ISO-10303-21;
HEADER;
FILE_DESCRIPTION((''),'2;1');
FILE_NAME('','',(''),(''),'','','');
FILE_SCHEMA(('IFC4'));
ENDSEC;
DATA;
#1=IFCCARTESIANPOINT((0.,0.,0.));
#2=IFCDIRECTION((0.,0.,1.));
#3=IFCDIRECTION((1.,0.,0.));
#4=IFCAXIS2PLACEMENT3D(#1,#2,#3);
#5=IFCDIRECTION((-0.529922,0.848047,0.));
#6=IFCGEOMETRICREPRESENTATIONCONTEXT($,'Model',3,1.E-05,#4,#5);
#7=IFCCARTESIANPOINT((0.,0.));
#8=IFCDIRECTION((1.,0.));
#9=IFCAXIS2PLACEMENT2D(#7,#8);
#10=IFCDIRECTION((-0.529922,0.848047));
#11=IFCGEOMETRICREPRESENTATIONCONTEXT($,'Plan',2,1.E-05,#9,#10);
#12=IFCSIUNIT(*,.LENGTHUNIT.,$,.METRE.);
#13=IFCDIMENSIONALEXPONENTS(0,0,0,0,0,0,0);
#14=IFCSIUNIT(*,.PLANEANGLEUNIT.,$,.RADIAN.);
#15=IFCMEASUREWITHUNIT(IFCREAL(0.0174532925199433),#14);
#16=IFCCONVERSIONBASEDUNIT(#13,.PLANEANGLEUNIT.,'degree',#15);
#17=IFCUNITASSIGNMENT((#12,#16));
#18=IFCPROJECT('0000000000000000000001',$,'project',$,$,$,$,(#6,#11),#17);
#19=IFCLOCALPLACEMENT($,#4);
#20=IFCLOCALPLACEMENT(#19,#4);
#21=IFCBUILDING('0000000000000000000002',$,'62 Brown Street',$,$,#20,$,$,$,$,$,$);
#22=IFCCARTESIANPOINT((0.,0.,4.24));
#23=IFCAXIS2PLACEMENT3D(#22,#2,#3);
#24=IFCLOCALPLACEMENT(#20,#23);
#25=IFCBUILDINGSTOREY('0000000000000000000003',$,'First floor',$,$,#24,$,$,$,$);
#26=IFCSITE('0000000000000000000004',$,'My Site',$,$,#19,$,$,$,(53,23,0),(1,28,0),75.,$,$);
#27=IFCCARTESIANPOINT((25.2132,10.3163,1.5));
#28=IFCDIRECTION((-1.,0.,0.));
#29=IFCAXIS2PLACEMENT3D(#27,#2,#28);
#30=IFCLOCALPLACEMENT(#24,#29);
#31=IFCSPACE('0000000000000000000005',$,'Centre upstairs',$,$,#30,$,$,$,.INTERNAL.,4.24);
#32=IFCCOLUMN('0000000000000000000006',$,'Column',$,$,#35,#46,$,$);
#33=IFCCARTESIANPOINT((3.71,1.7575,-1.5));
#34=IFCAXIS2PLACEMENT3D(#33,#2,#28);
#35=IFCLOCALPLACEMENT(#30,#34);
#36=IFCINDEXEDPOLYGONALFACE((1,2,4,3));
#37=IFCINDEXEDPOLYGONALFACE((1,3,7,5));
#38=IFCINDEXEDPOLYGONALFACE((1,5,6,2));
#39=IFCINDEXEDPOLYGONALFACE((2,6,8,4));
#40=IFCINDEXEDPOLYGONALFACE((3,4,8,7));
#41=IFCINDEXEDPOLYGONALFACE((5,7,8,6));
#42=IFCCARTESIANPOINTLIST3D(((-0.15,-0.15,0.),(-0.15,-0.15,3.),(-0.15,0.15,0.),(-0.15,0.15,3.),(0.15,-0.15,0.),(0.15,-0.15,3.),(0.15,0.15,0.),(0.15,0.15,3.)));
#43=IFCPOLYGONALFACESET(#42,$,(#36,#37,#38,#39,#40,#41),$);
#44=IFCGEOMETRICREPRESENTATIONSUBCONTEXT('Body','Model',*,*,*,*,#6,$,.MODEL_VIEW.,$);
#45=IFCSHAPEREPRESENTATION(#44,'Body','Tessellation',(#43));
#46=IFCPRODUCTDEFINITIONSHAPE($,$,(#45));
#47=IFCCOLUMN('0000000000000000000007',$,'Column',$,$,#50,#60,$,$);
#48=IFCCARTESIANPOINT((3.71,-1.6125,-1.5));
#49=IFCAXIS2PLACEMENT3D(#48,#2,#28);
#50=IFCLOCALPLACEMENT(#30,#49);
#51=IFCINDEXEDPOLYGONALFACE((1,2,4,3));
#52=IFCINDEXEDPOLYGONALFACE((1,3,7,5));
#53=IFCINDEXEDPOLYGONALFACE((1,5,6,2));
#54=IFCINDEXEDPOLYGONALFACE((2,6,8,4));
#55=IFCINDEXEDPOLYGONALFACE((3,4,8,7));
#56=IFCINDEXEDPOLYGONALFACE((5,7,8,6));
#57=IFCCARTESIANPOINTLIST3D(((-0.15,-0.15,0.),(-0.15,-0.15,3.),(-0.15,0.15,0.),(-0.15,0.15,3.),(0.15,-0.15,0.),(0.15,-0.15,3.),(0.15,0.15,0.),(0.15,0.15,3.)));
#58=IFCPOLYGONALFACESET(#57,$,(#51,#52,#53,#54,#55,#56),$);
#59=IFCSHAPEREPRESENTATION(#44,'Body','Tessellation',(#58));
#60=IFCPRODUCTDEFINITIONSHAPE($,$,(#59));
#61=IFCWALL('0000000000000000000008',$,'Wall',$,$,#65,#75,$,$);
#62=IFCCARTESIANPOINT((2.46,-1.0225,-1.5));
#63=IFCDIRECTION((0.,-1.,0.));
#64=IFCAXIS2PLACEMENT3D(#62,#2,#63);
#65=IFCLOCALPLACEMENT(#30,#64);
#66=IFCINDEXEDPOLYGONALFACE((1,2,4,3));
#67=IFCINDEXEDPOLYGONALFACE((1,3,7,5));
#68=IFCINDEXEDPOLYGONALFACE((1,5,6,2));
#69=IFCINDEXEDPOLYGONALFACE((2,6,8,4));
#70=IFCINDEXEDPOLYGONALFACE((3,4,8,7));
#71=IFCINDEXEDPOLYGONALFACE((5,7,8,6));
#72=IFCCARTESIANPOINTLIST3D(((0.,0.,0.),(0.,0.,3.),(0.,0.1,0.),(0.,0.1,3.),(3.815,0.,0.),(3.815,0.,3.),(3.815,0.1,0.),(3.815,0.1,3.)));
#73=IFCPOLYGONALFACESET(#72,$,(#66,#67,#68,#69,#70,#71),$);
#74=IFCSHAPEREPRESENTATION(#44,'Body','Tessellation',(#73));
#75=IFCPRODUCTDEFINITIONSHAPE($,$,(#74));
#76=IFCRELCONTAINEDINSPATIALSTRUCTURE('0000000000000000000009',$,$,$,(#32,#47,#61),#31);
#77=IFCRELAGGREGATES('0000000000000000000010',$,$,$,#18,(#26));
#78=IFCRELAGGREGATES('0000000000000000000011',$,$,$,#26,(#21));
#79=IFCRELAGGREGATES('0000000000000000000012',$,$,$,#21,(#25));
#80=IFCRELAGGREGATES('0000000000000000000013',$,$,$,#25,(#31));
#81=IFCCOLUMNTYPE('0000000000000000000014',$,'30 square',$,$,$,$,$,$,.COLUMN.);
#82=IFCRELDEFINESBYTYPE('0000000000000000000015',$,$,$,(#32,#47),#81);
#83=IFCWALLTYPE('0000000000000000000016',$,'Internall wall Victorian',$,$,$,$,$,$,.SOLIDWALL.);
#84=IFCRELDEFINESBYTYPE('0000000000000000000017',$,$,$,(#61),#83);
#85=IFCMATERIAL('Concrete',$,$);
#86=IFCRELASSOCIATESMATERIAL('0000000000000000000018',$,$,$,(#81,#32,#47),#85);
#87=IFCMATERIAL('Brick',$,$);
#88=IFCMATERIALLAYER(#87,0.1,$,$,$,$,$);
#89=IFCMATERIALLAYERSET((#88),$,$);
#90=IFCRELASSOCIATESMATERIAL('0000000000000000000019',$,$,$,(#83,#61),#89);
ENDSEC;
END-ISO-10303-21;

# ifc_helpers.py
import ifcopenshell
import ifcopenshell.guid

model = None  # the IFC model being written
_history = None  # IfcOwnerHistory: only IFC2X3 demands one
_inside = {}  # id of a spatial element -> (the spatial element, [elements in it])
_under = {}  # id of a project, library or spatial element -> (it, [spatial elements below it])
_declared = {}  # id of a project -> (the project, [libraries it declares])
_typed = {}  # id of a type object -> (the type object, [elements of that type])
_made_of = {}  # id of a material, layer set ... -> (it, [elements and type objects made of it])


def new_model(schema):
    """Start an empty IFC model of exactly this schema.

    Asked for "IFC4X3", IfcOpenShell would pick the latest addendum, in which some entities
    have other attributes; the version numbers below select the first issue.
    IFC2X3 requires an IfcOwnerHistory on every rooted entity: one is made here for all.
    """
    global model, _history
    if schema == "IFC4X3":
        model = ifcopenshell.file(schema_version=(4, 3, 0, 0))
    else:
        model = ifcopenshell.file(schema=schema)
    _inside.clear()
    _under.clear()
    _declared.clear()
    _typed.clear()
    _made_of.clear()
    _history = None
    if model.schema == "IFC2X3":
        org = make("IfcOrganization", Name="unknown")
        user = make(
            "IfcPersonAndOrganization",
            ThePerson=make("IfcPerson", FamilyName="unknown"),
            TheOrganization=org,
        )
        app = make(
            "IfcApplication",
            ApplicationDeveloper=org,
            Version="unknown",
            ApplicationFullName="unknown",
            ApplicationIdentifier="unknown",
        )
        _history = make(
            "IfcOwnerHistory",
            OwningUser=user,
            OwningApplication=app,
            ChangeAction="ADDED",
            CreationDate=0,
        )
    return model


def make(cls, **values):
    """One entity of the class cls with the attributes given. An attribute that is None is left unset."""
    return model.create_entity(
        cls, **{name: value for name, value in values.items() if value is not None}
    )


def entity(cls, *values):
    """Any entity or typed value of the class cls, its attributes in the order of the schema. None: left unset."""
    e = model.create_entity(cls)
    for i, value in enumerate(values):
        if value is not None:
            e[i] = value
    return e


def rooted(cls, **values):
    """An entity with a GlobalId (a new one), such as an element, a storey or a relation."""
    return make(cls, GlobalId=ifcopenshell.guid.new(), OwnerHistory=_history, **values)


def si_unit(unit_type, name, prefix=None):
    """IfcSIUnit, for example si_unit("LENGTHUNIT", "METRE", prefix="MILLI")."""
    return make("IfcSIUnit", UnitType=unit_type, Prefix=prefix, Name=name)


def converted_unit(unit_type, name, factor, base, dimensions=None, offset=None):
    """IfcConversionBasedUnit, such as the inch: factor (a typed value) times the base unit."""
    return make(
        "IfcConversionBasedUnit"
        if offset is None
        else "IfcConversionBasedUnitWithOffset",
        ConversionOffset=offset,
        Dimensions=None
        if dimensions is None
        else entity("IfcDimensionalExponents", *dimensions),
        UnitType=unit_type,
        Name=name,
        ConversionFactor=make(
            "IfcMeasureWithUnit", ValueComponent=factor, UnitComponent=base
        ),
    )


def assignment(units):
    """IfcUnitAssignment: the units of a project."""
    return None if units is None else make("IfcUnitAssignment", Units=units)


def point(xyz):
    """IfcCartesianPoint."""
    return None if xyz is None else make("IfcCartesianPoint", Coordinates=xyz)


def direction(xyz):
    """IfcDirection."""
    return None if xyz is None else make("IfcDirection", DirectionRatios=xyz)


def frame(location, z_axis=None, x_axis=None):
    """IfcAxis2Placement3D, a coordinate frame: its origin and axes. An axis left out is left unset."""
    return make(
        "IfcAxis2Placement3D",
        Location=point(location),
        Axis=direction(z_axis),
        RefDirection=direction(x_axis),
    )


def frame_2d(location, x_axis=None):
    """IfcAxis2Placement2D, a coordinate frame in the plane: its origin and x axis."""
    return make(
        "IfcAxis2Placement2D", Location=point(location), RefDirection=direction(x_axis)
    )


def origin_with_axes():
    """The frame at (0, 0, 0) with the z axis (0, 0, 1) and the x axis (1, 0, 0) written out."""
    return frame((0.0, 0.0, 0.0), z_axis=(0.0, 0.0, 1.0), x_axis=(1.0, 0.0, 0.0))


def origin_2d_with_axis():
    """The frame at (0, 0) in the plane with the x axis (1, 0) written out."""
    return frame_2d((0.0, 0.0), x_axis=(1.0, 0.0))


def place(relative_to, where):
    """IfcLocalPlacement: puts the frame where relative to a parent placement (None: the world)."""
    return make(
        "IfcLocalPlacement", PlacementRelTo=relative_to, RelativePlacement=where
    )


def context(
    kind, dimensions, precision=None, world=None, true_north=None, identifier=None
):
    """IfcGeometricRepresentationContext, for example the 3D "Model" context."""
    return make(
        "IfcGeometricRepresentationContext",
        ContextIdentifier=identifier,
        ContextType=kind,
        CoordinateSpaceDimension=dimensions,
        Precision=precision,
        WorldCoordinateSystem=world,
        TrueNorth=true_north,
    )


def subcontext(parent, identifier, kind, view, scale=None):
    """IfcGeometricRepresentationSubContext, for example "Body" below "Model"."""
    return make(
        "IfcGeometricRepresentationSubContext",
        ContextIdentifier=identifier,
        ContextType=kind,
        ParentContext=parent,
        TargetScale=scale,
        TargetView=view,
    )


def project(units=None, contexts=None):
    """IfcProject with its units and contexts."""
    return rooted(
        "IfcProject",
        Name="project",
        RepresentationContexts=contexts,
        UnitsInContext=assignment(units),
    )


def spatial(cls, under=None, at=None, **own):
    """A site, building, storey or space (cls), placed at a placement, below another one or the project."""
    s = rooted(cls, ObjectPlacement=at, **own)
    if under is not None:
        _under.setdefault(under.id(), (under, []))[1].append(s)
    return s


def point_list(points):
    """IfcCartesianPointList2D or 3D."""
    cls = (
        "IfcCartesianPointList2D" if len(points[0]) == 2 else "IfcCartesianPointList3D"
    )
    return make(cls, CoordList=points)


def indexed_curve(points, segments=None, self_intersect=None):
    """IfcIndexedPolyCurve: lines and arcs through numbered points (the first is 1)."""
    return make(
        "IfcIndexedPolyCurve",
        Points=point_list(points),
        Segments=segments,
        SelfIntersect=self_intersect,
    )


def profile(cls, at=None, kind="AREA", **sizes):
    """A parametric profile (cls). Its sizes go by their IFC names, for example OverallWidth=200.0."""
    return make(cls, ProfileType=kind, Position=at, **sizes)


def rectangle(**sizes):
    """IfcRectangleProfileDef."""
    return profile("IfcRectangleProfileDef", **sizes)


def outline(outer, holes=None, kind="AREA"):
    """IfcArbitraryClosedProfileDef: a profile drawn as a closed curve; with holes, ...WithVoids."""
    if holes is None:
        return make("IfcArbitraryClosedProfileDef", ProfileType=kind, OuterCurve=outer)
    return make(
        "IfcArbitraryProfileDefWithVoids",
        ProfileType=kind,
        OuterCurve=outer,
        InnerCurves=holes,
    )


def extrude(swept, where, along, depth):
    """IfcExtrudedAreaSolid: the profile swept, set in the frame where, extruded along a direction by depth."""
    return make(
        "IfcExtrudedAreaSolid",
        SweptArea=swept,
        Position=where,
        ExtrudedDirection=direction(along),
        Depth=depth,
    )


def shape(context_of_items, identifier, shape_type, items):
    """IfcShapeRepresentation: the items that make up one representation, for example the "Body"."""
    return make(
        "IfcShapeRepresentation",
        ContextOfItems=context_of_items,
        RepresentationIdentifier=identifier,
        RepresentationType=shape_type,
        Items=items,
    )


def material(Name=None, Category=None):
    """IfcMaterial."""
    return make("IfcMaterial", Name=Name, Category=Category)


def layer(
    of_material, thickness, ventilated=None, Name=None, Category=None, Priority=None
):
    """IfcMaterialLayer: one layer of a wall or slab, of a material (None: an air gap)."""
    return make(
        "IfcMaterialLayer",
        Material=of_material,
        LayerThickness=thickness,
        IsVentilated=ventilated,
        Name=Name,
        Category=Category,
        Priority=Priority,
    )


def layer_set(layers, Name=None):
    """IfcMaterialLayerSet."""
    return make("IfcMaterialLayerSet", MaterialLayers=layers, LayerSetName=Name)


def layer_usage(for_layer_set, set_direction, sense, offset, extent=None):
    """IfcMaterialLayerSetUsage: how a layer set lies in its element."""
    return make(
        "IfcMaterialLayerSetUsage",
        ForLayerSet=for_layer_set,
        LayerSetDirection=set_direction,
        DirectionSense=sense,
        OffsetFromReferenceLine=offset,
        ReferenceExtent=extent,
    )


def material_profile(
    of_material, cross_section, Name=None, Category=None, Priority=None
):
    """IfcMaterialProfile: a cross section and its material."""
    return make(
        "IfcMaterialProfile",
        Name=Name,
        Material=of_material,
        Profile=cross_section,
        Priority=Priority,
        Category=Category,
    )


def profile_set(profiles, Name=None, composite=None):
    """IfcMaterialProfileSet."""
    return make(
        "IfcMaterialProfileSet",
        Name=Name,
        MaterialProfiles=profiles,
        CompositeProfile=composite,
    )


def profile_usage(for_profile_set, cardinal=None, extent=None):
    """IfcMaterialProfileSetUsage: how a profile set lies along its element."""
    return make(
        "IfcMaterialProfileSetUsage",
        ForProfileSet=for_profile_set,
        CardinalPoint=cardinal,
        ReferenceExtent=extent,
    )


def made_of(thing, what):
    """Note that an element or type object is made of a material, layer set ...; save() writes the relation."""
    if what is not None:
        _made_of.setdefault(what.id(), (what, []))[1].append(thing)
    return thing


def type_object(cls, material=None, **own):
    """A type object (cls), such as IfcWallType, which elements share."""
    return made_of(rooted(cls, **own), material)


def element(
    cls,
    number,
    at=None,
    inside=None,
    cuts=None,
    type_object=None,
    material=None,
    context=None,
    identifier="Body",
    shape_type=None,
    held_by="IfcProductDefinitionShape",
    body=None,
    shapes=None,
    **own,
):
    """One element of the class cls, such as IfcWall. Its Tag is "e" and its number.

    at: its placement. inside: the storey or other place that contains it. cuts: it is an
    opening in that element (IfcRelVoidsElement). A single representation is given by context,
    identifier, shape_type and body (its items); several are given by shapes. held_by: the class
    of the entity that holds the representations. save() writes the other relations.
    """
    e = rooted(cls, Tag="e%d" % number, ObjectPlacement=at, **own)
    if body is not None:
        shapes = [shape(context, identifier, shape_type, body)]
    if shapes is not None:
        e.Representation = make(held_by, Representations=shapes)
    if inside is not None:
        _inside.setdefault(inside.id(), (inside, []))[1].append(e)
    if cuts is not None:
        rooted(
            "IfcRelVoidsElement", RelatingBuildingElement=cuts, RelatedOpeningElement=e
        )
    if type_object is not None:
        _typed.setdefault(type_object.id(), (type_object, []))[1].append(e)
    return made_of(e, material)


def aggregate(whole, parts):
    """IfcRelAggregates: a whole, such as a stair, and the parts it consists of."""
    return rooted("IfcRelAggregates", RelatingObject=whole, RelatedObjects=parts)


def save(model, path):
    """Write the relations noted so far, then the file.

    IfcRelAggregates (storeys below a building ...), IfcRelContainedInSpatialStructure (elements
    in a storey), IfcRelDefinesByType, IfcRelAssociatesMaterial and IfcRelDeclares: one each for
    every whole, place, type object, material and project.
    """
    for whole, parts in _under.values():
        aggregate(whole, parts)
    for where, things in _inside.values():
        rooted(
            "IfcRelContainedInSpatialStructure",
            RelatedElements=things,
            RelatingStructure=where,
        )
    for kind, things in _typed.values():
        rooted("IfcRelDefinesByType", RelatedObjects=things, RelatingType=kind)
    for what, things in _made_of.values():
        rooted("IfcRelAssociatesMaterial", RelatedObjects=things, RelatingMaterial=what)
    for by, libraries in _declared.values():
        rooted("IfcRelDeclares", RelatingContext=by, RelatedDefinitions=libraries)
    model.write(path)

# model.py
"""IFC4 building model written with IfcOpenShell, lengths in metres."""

from ifc_helpers import new_model, entity, si_unit, converted_unit, direction, frame, origin_with_axes, origin_2d_with_axis, place, context, subcontext, project, spatial, indexed_curve, rectangle, outline, extrude, material, layer, layer_set, layer_usage, material_profile, profile_set, profile_usage, type_object, element, save


model = new_model("IFC4")

# Units and contexts
model_context = context("Model", 3, precision=1e-05, world=origin_with_axes(), true_north=direction((-0.529922, 0.848047, 0.0)))
plan_context = context("Plan", 2, precision=1e-05, world=origin_2d_with_axis(), true_north=direction((-0.529922, 0.848047)))
body_context_1 = subcontext(model_context, "Body", "Model", "MODEL_VIEW")
ifc_project = project(units=[si_unit("LENGTHUNIT", "METRE"), converted_unit("PLANEANGLEUNIT", "degree", entity("IfcReal", 0.0174532925199433), si_unit("PLANEANGLEUNIT", "RADIAN"), dimensions=[0, 0, 0, 0, 0, 0, 0])], contexts=[model_context, plan_context])

# Site, building, storey, space
site_placement = place(None, origin_with_axes())
site = spatial("IfcSite", under=ifc_project, at=site_placement, Name="My Site", RefLatitude=(53, 23, 0), RefLongitude=(1, 28, 0), RefElevation=75.0)
building_placement = place(site_placement, origin_with_axes())
building = spatial("IfcBuilding", under=site, at=building_placement, Name="62 Brown Street")
storey_placement = place(building_placement, frame((0.0, 0.0, 4.24), z_axis=(0.0, 0.0, 1.0), x_axis=(1.0, 0.0, 0.0)))
storey = spatial("IfcBuildingStorey", under=building, at=storey_placement, Name="First floor")
space_placement = place(storey_placement, frame((25.2132, 10.3163, 1.5), z_axis=(0.0, 0.0, 1.0), x_axis=(-1.0, 0.0, 0.0)))
space = spatial("IfcSpace", under=storey, at=space_placement, Name="Centre upstairs", PredefinedType="INTERNAL", ElevationWithFlooring=4.24)

# Columns
ifc_material_1 = material(Name="Concrete")
ifc_material_profile_1 = material_profile(ifc_material_1, rectangle(XDim=0.3, YDim=0.3))
ifc_profile_set_1 = profile_set([ifc_material_profile_1])
ifc_profile_usage_1 = profile_usage(ifc_profile_set_1, cardinal=5)
column_type = type_object("IfcColumnType", Name="30 square", PredefinedType="COLUMN", material=ifc_profile_set_1)
column_1_placement = place(space_placement, frame((3.71, 1.7575, -1.5), z_axis=(0.0, 0.0, 1.0), x_axis=(-1.0, 0.0, 0.0)))
element("IfcColumn", 1, at=column_1_placement, inside=space, type_object=column_type, material=ifc_profile_usage_1, Name="Column", context=body_context_1, shape_type="SweptSolid", body=[
    extrude(rectangle(XDim=0.3, YDim=0.3), origin_with_axes(), (0.0, 0.0, 1.0), 3.0),
])
ifc_profile_usage_2 = profile_usage(ifc_profile_set_1, cardinal=5)
column_2_placement = place(space_placement, frame((3.71, -1.6125, -1.5), z_axis=(0.0, 0.0, 1.0), x_axis=(-1.0, 0.0, 0.0)))
element("IfcColumn", 2, at=column_2_placement, inside=space, type_object=column_type, material=ifc_profile_usage_2, Name="Column", context=body_context_1, shape_type="SweptSolid", body=[
    extrude(rectangle(XDim=0.3, YDim=0.3), origin_with_axes(), (0.0, 0.0, 1.0), 3.0),
])

# Shared definitions
ifc_material_2 = material(Name="Brick")
ifc_layer_1 = layer(ifc_material_2, 0.1)
ifc_layer_set_1 = layer_set([ifc_layer_1])
wall_type_1 = type_object("IfcWallType", Name="Internall wall Victorian", PredefinedType="SOLIDWALL", material=ifc_layer_set_1)

# Wall
ifc_layer_usage_1 = layer_usage(ifc_layer_set_1, "AXIS2", "POSITIVE", 0.0)
wall_1_placement = place(space_placement, frame((2.46, -1.0225, -1.5), z_axis=(0.0, 0.0, 1.0), x_axis=(0.0, -1.0, 0.0)))
element("IfcWall", 3, at=wall_1_placement, inside=space, type_object=wall_type_1, material=ifc_layer_usage_1, Name="Wall", context=body_context_1, shape_type="SweptSolid", body=[
    extrude(outline(indexed_curve([(0.0, 0.0), (0.0, 0.1), (3.815, 0.1), (3.815, 0.0), (0.0, 0.0)], self_intersect=False)), origin_with_axes(), (0.0, 0.0, 1.0), 3.0),
])

save(model, "model.ifc")
